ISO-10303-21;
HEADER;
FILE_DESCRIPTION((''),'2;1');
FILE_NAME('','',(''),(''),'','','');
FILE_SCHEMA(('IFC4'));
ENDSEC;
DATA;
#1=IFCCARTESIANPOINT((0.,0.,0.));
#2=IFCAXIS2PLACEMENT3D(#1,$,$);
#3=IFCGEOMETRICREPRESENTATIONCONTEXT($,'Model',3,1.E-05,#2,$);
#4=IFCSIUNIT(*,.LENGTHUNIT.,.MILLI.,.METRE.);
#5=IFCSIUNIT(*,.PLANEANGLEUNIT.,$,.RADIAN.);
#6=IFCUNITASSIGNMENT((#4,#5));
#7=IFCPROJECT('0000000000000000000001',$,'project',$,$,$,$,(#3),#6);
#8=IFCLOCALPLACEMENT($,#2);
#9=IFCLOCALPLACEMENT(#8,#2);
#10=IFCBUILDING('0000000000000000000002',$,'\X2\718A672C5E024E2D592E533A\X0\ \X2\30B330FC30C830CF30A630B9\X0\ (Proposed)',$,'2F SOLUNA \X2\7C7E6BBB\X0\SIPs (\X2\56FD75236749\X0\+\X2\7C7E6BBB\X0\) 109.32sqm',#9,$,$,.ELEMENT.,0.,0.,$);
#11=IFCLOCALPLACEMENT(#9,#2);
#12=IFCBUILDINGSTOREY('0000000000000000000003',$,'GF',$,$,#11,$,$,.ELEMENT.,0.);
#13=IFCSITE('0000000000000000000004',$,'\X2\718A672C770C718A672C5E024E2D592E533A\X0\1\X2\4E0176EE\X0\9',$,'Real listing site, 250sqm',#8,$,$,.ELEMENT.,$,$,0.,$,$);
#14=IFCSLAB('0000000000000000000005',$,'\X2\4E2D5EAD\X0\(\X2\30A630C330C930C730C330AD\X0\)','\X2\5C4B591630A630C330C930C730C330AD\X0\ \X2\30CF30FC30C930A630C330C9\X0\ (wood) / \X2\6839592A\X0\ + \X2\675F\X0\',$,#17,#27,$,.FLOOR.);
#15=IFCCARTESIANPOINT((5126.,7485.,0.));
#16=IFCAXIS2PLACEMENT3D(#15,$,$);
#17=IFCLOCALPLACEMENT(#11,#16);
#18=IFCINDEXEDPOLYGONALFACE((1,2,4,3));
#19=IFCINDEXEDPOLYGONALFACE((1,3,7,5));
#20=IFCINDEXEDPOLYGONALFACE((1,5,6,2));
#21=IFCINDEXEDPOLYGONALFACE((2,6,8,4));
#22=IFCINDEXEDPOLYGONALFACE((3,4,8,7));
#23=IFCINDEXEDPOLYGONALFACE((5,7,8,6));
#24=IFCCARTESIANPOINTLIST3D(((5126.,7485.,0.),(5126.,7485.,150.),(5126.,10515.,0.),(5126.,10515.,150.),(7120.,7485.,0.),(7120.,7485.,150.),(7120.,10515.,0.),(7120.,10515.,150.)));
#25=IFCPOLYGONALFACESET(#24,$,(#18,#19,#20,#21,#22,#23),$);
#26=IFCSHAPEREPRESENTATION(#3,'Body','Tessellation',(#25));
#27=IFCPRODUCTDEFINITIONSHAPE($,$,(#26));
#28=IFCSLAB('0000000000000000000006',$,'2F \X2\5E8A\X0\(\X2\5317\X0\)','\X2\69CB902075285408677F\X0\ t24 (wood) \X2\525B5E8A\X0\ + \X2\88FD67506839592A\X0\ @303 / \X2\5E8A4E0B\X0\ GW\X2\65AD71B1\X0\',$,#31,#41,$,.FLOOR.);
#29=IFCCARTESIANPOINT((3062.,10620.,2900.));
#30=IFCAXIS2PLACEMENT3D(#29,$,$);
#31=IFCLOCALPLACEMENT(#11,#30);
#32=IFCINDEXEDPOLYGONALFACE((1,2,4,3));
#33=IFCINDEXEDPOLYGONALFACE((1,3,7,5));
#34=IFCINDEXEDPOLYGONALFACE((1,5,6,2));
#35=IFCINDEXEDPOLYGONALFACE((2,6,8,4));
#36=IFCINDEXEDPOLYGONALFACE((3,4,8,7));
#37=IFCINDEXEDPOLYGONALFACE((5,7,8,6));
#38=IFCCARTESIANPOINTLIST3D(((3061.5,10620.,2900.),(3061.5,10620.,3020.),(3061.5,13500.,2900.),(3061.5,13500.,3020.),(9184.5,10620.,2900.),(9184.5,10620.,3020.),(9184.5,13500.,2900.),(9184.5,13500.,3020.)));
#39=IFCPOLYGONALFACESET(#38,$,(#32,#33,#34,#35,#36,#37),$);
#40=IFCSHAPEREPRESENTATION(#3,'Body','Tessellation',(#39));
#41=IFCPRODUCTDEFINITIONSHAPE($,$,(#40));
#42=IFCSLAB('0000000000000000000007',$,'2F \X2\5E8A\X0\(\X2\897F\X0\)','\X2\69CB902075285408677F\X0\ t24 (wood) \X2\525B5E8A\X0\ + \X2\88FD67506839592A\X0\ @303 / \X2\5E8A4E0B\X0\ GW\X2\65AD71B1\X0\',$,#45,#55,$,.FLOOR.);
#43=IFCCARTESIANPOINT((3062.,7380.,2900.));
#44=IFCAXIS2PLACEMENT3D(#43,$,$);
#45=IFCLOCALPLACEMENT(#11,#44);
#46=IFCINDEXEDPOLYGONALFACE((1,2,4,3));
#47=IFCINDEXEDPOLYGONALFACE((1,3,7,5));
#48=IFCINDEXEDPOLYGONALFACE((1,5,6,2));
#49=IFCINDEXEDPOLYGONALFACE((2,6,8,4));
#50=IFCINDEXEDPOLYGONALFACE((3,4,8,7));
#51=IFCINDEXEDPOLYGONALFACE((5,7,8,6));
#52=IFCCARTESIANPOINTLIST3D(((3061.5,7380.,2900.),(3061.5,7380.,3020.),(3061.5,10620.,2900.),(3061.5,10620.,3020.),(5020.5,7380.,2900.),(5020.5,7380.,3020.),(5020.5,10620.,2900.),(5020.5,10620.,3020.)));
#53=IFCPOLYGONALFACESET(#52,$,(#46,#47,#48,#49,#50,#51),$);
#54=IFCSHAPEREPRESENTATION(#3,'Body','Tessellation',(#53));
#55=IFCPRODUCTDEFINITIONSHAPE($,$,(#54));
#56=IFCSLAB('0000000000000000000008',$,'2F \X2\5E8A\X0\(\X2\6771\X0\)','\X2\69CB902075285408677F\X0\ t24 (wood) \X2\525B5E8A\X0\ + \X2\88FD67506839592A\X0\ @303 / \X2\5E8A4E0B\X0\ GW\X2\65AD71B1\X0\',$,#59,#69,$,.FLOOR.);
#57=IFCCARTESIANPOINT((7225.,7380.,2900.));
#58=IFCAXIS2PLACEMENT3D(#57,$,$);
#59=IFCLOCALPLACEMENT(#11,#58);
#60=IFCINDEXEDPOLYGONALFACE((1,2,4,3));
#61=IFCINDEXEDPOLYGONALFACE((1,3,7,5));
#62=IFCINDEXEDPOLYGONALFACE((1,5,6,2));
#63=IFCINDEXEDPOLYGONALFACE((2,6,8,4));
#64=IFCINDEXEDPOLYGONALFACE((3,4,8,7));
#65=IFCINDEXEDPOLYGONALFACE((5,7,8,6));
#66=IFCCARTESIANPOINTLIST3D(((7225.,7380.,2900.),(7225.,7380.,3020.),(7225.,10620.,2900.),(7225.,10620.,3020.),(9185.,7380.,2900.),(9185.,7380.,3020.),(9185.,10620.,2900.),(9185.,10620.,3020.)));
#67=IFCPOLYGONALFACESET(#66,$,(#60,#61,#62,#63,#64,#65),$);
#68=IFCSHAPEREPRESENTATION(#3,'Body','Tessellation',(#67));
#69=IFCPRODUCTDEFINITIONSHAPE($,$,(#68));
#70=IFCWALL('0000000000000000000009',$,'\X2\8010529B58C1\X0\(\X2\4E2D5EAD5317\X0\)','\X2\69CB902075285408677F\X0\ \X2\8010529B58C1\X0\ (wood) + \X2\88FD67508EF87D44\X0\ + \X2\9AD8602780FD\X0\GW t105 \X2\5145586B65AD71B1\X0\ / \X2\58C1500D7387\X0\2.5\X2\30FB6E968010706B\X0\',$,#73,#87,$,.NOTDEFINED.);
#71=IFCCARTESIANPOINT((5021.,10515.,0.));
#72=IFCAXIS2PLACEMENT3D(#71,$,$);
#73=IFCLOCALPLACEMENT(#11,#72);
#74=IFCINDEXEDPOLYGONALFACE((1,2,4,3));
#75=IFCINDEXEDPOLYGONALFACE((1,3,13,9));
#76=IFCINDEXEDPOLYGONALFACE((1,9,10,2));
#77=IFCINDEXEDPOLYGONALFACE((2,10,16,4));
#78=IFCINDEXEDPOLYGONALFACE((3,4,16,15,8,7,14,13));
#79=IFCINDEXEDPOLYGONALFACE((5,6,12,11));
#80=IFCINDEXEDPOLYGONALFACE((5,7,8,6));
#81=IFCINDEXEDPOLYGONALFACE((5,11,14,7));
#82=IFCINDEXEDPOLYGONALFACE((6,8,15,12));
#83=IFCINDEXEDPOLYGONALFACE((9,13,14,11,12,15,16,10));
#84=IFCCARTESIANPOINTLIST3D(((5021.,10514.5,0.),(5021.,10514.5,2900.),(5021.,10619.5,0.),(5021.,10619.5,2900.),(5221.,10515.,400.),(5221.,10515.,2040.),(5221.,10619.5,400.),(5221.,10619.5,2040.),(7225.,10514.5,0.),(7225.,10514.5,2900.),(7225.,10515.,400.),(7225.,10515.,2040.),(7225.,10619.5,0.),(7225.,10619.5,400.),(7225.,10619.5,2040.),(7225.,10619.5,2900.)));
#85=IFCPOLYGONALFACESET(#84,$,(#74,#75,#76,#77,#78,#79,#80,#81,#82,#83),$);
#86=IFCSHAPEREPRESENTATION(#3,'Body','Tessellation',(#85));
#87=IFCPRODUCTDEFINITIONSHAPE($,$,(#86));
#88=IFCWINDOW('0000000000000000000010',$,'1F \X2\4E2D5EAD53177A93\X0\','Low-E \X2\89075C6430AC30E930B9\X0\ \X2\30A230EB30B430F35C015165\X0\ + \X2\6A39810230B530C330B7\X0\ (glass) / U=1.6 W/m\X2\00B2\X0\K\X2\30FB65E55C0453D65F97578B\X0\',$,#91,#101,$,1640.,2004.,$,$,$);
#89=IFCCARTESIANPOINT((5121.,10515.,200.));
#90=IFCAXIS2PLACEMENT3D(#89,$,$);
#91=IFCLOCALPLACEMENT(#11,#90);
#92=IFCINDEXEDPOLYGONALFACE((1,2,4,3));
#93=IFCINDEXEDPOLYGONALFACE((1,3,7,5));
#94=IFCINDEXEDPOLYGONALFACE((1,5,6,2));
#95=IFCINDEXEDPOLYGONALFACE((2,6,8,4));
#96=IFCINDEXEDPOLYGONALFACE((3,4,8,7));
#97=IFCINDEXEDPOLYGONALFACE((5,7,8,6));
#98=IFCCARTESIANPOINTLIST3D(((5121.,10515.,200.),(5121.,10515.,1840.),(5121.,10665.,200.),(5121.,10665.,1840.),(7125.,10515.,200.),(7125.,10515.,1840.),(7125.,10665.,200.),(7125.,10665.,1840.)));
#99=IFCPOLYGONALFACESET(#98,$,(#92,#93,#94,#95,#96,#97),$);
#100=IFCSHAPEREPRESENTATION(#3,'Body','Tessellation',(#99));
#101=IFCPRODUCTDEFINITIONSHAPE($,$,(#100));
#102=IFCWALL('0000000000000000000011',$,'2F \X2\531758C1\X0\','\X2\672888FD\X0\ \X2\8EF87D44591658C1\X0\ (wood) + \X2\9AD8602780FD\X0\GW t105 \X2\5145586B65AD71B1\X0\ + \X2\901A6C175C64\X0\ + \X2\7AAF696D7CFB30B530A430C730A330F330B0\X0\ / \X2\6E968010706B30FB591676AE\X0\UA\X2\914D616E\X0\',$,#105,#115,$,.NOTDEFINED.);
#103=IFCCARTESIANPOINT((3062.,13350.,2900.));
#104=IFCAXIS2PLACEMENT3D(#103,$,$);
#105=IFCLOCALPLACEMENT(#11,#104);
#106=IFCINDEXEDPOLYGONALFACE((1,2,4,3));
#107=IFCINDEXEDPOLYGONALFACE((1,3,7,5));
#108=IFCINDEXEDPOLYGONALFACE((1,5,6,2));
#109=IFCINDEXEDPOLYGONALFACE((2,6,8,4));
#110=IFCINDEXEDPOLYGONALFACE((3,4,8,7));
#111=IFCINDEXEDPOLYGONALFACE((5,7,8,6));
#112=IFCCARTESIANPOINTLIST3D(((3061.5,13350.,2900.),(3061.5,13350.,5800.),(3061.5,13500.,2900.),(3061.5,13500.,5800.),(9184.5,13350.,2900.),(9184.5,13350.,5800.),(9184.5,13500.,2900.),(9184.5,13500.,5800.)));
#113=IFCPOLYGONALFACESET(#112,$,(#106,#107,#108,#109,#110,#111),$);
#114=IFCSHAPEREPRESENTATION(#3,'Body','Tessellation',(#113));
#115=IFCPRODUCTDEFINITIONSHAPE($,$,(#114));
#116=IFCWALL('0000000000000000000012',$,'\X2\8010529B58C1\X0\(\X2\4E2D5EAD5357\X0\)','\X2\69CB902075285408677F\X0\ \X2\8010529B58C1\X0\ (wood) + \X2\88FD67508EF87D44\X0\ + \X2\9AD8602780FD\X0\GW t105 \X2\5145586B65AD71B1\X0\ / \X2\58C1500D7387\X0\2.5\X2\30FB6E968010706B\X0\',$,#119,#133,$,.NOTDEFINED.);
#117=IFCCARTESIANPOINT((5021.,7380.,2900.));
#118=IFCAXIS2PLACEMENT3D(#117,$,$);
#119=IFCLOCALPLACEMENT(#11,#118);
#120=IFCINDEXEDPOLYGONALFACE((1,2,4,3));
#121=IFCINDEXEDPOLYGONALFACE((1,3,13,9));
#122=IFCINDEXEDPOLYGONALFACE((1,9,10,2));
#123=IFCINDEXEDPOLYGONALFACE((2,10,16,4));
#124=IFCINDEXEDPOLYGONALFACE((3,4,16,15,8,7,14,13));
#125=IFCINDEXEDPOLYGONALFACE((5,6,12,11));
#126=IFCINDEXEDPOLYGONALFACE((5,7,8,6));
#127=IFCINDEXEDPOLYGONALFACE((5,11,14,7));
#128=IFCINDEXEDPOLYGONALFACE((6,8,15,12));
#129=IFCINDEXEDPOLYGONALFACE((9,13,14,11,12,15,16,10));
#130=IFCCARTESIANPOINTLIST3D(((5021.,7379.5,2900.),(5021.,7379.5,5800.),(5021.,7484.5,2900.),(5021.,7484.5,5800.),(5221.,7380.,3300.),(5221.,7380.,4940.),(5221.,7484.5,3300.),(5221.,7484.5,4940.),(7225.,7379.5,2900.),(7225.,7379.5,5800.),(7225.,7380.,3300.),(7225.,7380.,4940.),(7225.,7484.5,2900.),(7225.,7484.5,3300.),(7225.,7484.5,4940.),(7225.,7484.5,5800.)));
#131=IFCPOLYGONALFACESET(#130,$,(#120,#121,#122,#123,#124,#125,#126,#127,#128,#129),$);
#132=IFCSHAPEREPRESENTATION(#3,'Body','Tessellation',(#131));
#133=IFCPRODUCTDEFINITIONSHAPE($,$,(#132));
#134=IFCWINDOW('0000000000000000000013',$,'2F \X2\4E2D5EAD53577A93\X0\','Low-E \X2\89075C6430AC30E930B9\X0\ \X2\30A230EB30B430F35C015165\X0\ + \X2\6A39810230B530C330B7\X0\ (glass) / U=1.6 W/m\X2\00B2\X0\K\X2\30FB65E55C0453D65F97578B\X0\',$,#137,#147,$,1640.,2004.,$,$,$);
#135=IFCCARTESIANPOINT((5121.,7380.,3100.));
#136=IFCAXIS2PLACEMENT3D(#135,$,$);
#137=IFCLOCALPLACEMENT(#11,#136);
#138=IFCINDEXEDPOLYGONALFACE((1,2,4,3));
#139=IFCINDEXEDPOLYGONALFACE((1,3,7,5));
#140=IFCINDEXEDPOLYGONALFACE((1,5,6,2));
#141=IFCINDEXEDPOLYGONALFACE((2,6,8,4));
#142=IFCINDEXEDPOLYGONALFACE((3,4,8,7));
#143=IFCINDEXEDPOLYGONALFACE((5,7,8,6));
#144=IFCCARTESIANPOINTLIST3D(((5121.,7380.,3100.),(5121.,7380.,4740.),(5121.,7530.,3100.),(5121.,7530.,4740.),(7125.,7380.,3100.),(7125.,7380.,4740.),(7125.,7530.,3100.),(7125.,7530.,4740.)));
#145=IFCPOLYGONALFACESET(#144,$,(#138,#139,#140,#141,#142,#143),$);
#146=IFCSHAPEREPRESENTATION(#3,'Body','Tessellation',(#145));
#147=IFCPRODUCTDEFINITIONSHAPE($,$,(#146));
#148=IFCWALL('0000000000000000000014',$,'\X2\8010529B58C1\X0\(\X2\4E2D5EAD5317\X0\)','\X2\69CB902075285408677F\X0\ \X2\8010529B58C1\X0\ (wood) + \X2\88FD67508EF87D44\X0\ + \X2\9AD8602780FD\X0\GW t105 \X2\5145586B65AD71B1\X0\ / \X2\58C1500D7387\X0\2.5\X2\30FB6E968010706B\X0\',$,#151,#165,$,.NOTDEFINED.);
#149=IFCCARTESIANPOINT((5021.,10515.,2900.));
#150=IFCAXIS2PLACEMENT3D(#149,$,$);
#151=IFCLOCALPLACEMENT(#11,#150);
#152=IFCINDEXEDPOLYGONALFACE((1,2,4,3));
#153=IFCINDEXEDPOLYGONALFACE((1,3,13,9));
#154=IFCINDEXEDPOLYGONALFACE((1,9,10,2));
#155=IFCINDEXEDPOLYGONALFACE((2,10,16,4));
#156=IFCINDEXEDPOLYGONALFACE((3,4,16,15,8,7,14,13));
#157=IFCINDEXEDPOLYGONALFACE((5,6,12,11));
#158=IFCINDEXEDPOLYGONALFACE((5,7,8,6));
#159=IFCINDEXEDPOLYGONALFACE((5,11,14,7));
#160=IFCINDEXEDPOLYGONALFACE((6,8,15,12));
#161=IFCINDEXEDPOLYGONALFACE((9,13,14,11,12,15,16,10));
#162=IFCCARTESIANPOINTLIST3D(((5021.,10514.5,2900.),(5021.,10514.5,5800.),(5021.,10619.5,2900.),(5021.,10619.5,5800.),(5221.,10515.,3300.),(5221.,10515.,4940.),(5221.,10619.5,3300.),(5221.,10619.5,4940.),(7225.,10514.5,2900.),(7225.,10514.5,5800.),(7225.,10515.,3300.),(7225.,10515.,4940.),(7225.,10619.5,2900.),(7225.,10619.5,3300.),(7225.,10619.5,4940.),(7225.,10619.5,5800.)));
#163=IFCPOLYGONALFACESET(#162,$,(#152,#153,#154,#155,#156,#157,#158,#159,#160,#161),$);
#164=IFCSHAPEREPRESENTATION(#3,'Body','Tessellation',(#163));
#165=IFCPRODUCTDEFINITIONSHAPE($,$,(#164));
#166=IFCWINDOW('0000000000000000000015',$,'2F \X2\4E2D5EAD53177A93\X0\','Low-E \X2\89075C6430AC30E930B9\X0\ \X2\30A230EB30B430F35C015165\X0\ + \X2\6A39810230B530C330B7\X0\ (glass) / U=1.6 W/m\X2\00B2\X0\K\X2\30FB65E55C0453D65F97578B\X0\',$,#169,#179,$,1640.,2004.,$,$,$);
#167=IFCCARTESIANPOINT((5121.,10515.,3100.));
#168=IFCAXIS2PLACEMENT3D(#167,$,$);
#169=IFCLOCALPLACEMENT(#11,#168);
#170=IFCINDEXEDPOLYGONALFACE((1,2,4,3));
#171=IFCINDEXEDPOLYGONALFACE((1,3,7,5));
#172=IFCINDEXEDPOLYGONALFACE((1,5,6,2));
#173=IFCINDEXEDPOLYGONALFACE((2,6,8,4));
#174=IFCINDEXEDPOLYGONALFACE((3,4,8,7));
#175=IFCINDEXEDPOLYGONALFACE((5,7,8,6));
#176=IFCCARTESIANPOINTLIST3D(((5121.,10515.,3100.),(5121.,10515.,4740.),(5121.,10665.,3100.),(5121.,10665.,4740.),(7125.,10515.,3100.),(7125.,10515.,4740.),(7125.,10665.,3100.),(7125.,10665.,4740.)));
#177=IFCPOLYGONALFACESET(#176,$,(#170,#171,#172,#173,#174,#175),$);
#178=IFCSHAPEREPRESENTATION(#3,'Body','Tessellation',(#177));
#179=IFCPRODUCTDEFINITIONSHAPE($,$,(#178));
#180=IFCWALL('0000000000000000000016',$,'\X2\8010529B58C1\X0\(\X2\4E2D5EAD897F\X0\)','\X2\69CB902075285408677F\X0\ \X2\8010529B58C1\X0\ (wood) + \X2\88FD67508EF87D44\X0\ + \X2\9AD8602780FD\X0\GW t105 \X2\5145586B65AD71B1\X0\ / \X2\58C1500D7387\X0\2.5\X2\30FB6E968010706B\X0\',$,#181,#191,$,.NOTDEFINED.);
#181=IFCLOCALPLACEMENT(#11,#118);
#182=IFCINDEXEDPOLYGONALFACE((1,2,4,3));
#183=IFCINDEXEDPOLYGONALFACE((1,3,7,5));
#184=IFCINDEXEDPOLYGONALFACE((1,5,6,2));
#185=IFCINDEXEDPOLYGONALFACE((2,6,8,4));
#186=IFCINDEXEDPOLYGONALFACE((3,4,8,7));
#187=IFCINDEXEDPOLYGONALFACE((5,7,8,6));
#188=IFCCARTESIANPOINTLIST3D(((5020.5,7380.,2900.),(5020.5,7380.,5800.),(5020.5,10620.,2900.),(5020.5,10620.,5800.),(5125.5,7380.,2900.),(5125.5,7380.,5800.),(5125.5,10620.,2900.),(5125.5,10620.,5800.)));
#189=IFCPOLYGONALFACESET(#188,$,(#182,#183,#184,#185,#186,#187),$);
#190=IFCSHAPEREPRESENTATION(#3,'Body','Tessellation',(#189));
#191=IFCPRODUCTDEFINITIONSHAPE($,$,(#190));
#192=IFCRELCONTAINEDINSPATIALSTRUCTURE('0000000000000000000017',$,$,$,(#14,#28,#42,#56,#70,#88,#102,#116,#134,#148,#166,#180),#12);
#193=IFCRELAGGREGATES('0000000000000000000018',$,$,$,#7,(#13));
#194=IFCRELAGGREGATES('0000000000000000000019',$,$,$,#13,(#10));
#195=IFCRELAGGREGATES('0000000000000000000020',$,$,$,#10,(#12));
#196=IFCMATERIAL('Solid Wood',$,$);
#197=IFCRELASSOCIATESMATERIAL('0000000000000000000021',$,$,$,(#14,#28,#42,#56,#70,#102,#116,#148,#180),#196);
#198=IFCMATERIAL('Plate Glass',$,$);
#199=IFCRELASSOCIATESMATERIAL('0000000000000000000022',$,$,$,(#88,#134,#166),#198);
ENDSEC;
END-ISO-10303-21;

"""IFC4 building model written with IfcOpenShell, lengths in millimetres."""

from ifc_helpers import new_model, si_unit, frame, frame_2d, origin, place, context, project, spatial, rectangle, extrude, material, element, fill, save


model = new_model("IFC4")

# Units and contexts
model_context = context("Model", 3, precision=1e-05, world=origin())
ifc_project = project(units=[si_unit("LENGTHUNIT", "METRE", prefix="MILLI"), si_unit("PLANEANGLEUNIT", "RADIAN")], contexts=[model_context])

# Site, building, storey
site_placement = place(None, origin())
site = spatial("IfcSite", under=ifc_project, at=site_placement, Name="熊本県熊本市中央区1丁目9", ObjectType="Real listing site, 250sqm", CompositionType="ELEMENT", RefElevation=0.0)
building_placement = place(site_placement, origin())
building = spatial("IfcBuilding", under=site, at=building_placement, Name="熊本市中央区 コートハウス (Proposed)", ObjectType="2F SOLUNA 籾殻SIPs (国産杉+籾殻) 109.32sqm", CompositionType="ELEMENT", ElevationOfRefHeight=0.0, ElevationOfTerrain=0.0)
storey_placement = place(building_placement, origin())
storey = spatial("IfcBuildingStorey", under=building, at=storey_placement, Name="GF", CompositionType="ELEMENT", Elevation=0.0)

# Slabs
ifc_material_1 = material(Name="Solid Wood")
slab_1_placement = place(storey_placement, frame((5126.0, 7485.0, 0.0)))
element("IfcSlab", 1, at=slab_1_placement, inside=storey, material=ifc_material_1, Name="中庭(ウッドデッキ)", Description="屋外ウッドデッキ ハードウッド (wood) / 根太 + 束", PredefinedType="FLOOR", context=model_context, shape_type="SweptSolid", body=[
    extrude(rectangle(XDim=1994.0, YDim=3030.0, at=frame_2d((997.0, 1515.0))), frame((5126.0, 7485.0, 0.0)), (0.0, 0.0, 1.0), 150.0),
])
slab_2_placement = place(storey_placement, frame((3062.0, 10620.0, 2900.0)))
element("IfcSlab", 2, at=slab_2_placement, inside=storey, material=ifc_material_1, Name="2F 床(北)", Description="構造用合板 t24 (wood) 剛床 + 製材根太 @303 / 床下 GW断熱", PredefinedType="FLOOR", context=model_context, shape_type="SweptSolid", body=[
    extrude(rectangle(XDim=6123.0, YDim=2880.0, at=frame_2d((3061.0, 1440.0))), frame((3062.0, 10620.0, 2900.0)), (0.0, 0.0, 1.0), 120.0),
])
slab_3_placement = place(storey_placement, frame((3062.0, 7380.0, 2900.0)))
element("IfcSlab", 3, at=slab_3_placement, inside=storey, material=ifc_material_1, Name="2F 床(西)", Description="構造用合板 t24 (wood) 剛床 + 製材根太 @303 / 床下 GW断熱", PredefinedType="FLOOR", context=model_context, shape_type="SweptSolid", body=[
    extrude(rectangle(XDim=1959.0, YDim=3240.0, at=frame_2d((979.0, 1620.0))), frame((3062.0, 7380.0, 2900.0)), (0.0, 0.0, 1.0), 120.0),
])
slab_4_placement = place(storey_placement, frame((7225.0, 7380.0, 2900.0)))
element("IfcSlab", 4, at=slab_4_placement, inside=storey, material=ifc_material_1, Name="2F 床(東)", Description="構造用合板 t24 (wood) 剛床 + 製材根太 @303 / 床下 GW断熱", PredefinedType="FLOOR", context=model_context, shape_type="SweptSolid", body=[
    extrude(rectangle(XDim=1960.0, YDim=3240.0, at=frame_2d((980.0, 1620.0))), frame((7225.0, 7380.0, 2900.0)), (0.0, 0.0, 1.0), 120.0),
])

# Wall, opening, window
wall_1_placement = place(storey_placement, frame((5021.0, 10515.0, 0.0)))
wall_1 = element("IfcWall", 5, at=wall_1_placement, inside=storey, material=ifc_material_1, Name="耐力壁(中庭北)", Description="構造用合板 耐力壁 (wood) + 製材軸組 + 高性能GW t105 充填断熱 / 壁倍率2.5・準耐火", PredefinedType="NOTDEFINED", context=model_context, shape_type="SweptSolid", body=[
    extrude(rectangle(XDim=2204.0, YDim=105.0, at=frame_2d((1102.0, 52.0))), frame((5021.0, 10515.0, 0.0)), (0.0, 0.0, 1.0), 2900.0),
])
opening_1_placement = place(storey_placement, frame((5121.0, 10515.0, 200.0)))
opening_1 = element("IfcOpeningElement", 6, at=opening_1_placement, cuts=wall_1, PredefinedType="NOTDEFINED", context=model_context, shape_type="SweptSolid", body=[
    extrude(rectangle(XDim=2004.0, YDim=150.0, at=frame_2d((1002.0, 75.0))), frame((5121.0, 10515.0, 200.0)), (0.0, 0.0, 1.0), 1640.0),
])
ifc_material_2 = material(Name="Plate Glass")
window_1_placement = place(storey_placement, frame((5121.0, 10515.0, 200.0)))
window_1 = element("IfcWindow", 7, at=window_1_placement, inside=storey, material=ifc_material_2, Name="1F 中庭北窓", Description="Low-E 複層ガラス アルゴン封入 + 樹脂サッシ (glass) / U=1.6 W/m²K・日射取得型", OverallHeight=1640.0, OverallWidth=2004.0, context=model_context, shape_type="SweptSolid", body=[
    extrude(rectangle(XDim=2004.0, YDim=150.0, at=frame_2d((1002.0, 75.0))), frame((5121.0, 10515.0, 200.0)), (0.0, 0.0, 1.0), 1640.0),
])
fill(opening_1, window_1)

# Wall
wall_2_placement = place(storey_placement, frame((3062.0, 13350.0, 2900.0)))
element("IfcWall", 8, at=wall_2_placement, inside=storey, material=ifc_material_1, Name="2F 北壁", Description="木製 軸組外壁 (wood) + 高性能GW t105 充填断熱 + 通気層 + 窯業系サイディング / 準耐火・外皮UA配慮", PredefinedType="NOTDEFINED", context=model_context, shape_type="SweptSolid", body=[
    extrude(rectangle(XDim=6123.0, YDim=150.0, at=frame_2d((3061.0, 75.0))), frame((3062.0, 13350.0, 2900.0)), (0.0, 0.0, 1.0), 2900.0),
])

# Walls, openings, windows
wall_3_placement = place(storey_placement, frame((5021.0, 7380.0, 2900.0)))
wall_3 = element("IfcWall", 9, at=wall_3_placement, inside=storey, material=ifc_material_1, Name="耐力壁(中庭南)", Description="構造用合板 耐力壁 (wood) + 製材軸組 + 高性能GW t105 充填断熱 / 壁倍率2.5・準耐火", PredefinedType="NOTDEFINED", context=model_context, shape_type="SweptSolid", body=[
    extrude(rectangle(XDim=2204.0, YDim=105.0, at=frame_2d((1102.0, 52.0))), frame((5021.0, 7380.0, 2900.0)), (0.0, 0.0, 1.0), 2900.0),
])
opening_2_placement = place(storey_placement, frame((5121.0, 7380.0, 3100.0)))
opening_2 = element("IfcOpeningElement", 10, at=opening_2_placement, cuts=wall_3, PredefinedType="NOTDEFINED", context=model_context, shape_type="SweptSolid", body=[
    extrude(rectangle(XDim=2004.0, YDim=150.0, at=frame_2d((1002.0, 75.0))), frame((5121.0, 7380.0, 3100.0)), (0.0, 0.0, 1.0), 1640.0),
])
window_2_placement = place(storey_placement, frame((5121.0, 7380.0, 3100.0)))
window_2 = element("IfcWindow", 11, at=window_2_placement, inside=storey, material=ifc_material_2, Name="2F 中庭南窓", Description="Low-E 複層ガラス アルゴン封入 + 樹脂サッシ (glass) / U=1.6 W/m²K・日射取得型", OverallHeight=1640.0, OverallWidth=2004.0, context=model_context, shape_type="SweptSolid", body=[
    extrude(rectangle(XDim=2004.0, YDim=150.0, at=frame_2d((1002.0, 75.0))), frame((5121.0, 7380.0, 3100.0)), (0.0, 0.0, 1.0), 1640.0),
])
fill(opening_2, window_2)
wall_4_placement = place(storey_placement, frame((5021.0, 10515.0, 2900.0)))
wall_4 = element("IfcWall", 12, at=wall_4_placement, inside=storey, material=ifc_material_1, Name="耐力壁(中庭北)", Description="構造用合板 耐力壁 (wood) + 製材軸組 + 高性能GW t105 充填断熱 / 壁倍率2.5・準耐火", PredefinedType="NOTDEFINED", context=model_context, shape_type="SweptSolid", body=[
    extrude(rectangle(XDim=2204.0, YDim=105.0, at=frame_2d((1102.0, 52.0))), frame((5021.0, 10515.0, 2900.0)), (0.0, 0.0, 1.0), 2900.0),
])
opening_3_placement = place(storey_placement, frame((5121.0, 10515.0, 3100.0)))
opening_3 = element("IfcOpeningElement", 13, at=opening_3_placement, cuts=wall_4, PredefinedType="NOTDEFINED", context=model_context, shape_type="SweptSolid", body=[
    extrude(rectangle(XDim=2004.0, YDim=150.0, at=frame_2d((1002.0, 75.0))), frame((5121.0, 10515.0, 3100.0)), (0.0, 0.0, 1.0), 1640.0),
])
window_3_placement = place(storey_placement, frame((5121.0, 10515.0, 3100.0)))
window_3 = element("IfcWindow", 14, at=window_3_placement, inside=storey, material=ifc_material_2, Name="2F 中庭北窓", Description="Low-E 複層ガラス アルゴン封入 + 樹脂サッシ (glass) / U=1.6 W/m²K・日射取得型", OverallHeight=1640.0, OverallWidth=2004.0, context=model_context, shape_type="SweptSolid", body=[
    extrude(rectangle(XDim=2004.0, YDim=150.0, at=frame_2d((1002.0, 75.0))), frame((5121.0, 10515.0, 3100.0)), (0.0, 0.0, 1.0), 1640.0),
])
fill(opening_3, window_3)

# Wall
wall_5_placement = place(storey_placement, frame((5021.0, 7380.0, 2900.0)))
element("IfcWall", 15, at=wall_5_placement, inside=storey, material=ifc_material_1, Name="耐力壁(中庭西)", Description="構造用合板 耐力壁 (wood) + 製材軸組 + 高性能GW t105 充填断熱 / 壁倍率2.5・準耐火", PredefinedType="NOTDEFINED", context=model_context, shape_type="SweptSolid", body=[
    extrude(rectangle(XDim=105.0, YDim=3240.0, at=frame_2d((52.0, 1620.0))), frame((5021.0, 7380.0, 2900.0)), (0.0, 0.0, 1.0), 2900.0),
])

save(model, "model.ifc")
